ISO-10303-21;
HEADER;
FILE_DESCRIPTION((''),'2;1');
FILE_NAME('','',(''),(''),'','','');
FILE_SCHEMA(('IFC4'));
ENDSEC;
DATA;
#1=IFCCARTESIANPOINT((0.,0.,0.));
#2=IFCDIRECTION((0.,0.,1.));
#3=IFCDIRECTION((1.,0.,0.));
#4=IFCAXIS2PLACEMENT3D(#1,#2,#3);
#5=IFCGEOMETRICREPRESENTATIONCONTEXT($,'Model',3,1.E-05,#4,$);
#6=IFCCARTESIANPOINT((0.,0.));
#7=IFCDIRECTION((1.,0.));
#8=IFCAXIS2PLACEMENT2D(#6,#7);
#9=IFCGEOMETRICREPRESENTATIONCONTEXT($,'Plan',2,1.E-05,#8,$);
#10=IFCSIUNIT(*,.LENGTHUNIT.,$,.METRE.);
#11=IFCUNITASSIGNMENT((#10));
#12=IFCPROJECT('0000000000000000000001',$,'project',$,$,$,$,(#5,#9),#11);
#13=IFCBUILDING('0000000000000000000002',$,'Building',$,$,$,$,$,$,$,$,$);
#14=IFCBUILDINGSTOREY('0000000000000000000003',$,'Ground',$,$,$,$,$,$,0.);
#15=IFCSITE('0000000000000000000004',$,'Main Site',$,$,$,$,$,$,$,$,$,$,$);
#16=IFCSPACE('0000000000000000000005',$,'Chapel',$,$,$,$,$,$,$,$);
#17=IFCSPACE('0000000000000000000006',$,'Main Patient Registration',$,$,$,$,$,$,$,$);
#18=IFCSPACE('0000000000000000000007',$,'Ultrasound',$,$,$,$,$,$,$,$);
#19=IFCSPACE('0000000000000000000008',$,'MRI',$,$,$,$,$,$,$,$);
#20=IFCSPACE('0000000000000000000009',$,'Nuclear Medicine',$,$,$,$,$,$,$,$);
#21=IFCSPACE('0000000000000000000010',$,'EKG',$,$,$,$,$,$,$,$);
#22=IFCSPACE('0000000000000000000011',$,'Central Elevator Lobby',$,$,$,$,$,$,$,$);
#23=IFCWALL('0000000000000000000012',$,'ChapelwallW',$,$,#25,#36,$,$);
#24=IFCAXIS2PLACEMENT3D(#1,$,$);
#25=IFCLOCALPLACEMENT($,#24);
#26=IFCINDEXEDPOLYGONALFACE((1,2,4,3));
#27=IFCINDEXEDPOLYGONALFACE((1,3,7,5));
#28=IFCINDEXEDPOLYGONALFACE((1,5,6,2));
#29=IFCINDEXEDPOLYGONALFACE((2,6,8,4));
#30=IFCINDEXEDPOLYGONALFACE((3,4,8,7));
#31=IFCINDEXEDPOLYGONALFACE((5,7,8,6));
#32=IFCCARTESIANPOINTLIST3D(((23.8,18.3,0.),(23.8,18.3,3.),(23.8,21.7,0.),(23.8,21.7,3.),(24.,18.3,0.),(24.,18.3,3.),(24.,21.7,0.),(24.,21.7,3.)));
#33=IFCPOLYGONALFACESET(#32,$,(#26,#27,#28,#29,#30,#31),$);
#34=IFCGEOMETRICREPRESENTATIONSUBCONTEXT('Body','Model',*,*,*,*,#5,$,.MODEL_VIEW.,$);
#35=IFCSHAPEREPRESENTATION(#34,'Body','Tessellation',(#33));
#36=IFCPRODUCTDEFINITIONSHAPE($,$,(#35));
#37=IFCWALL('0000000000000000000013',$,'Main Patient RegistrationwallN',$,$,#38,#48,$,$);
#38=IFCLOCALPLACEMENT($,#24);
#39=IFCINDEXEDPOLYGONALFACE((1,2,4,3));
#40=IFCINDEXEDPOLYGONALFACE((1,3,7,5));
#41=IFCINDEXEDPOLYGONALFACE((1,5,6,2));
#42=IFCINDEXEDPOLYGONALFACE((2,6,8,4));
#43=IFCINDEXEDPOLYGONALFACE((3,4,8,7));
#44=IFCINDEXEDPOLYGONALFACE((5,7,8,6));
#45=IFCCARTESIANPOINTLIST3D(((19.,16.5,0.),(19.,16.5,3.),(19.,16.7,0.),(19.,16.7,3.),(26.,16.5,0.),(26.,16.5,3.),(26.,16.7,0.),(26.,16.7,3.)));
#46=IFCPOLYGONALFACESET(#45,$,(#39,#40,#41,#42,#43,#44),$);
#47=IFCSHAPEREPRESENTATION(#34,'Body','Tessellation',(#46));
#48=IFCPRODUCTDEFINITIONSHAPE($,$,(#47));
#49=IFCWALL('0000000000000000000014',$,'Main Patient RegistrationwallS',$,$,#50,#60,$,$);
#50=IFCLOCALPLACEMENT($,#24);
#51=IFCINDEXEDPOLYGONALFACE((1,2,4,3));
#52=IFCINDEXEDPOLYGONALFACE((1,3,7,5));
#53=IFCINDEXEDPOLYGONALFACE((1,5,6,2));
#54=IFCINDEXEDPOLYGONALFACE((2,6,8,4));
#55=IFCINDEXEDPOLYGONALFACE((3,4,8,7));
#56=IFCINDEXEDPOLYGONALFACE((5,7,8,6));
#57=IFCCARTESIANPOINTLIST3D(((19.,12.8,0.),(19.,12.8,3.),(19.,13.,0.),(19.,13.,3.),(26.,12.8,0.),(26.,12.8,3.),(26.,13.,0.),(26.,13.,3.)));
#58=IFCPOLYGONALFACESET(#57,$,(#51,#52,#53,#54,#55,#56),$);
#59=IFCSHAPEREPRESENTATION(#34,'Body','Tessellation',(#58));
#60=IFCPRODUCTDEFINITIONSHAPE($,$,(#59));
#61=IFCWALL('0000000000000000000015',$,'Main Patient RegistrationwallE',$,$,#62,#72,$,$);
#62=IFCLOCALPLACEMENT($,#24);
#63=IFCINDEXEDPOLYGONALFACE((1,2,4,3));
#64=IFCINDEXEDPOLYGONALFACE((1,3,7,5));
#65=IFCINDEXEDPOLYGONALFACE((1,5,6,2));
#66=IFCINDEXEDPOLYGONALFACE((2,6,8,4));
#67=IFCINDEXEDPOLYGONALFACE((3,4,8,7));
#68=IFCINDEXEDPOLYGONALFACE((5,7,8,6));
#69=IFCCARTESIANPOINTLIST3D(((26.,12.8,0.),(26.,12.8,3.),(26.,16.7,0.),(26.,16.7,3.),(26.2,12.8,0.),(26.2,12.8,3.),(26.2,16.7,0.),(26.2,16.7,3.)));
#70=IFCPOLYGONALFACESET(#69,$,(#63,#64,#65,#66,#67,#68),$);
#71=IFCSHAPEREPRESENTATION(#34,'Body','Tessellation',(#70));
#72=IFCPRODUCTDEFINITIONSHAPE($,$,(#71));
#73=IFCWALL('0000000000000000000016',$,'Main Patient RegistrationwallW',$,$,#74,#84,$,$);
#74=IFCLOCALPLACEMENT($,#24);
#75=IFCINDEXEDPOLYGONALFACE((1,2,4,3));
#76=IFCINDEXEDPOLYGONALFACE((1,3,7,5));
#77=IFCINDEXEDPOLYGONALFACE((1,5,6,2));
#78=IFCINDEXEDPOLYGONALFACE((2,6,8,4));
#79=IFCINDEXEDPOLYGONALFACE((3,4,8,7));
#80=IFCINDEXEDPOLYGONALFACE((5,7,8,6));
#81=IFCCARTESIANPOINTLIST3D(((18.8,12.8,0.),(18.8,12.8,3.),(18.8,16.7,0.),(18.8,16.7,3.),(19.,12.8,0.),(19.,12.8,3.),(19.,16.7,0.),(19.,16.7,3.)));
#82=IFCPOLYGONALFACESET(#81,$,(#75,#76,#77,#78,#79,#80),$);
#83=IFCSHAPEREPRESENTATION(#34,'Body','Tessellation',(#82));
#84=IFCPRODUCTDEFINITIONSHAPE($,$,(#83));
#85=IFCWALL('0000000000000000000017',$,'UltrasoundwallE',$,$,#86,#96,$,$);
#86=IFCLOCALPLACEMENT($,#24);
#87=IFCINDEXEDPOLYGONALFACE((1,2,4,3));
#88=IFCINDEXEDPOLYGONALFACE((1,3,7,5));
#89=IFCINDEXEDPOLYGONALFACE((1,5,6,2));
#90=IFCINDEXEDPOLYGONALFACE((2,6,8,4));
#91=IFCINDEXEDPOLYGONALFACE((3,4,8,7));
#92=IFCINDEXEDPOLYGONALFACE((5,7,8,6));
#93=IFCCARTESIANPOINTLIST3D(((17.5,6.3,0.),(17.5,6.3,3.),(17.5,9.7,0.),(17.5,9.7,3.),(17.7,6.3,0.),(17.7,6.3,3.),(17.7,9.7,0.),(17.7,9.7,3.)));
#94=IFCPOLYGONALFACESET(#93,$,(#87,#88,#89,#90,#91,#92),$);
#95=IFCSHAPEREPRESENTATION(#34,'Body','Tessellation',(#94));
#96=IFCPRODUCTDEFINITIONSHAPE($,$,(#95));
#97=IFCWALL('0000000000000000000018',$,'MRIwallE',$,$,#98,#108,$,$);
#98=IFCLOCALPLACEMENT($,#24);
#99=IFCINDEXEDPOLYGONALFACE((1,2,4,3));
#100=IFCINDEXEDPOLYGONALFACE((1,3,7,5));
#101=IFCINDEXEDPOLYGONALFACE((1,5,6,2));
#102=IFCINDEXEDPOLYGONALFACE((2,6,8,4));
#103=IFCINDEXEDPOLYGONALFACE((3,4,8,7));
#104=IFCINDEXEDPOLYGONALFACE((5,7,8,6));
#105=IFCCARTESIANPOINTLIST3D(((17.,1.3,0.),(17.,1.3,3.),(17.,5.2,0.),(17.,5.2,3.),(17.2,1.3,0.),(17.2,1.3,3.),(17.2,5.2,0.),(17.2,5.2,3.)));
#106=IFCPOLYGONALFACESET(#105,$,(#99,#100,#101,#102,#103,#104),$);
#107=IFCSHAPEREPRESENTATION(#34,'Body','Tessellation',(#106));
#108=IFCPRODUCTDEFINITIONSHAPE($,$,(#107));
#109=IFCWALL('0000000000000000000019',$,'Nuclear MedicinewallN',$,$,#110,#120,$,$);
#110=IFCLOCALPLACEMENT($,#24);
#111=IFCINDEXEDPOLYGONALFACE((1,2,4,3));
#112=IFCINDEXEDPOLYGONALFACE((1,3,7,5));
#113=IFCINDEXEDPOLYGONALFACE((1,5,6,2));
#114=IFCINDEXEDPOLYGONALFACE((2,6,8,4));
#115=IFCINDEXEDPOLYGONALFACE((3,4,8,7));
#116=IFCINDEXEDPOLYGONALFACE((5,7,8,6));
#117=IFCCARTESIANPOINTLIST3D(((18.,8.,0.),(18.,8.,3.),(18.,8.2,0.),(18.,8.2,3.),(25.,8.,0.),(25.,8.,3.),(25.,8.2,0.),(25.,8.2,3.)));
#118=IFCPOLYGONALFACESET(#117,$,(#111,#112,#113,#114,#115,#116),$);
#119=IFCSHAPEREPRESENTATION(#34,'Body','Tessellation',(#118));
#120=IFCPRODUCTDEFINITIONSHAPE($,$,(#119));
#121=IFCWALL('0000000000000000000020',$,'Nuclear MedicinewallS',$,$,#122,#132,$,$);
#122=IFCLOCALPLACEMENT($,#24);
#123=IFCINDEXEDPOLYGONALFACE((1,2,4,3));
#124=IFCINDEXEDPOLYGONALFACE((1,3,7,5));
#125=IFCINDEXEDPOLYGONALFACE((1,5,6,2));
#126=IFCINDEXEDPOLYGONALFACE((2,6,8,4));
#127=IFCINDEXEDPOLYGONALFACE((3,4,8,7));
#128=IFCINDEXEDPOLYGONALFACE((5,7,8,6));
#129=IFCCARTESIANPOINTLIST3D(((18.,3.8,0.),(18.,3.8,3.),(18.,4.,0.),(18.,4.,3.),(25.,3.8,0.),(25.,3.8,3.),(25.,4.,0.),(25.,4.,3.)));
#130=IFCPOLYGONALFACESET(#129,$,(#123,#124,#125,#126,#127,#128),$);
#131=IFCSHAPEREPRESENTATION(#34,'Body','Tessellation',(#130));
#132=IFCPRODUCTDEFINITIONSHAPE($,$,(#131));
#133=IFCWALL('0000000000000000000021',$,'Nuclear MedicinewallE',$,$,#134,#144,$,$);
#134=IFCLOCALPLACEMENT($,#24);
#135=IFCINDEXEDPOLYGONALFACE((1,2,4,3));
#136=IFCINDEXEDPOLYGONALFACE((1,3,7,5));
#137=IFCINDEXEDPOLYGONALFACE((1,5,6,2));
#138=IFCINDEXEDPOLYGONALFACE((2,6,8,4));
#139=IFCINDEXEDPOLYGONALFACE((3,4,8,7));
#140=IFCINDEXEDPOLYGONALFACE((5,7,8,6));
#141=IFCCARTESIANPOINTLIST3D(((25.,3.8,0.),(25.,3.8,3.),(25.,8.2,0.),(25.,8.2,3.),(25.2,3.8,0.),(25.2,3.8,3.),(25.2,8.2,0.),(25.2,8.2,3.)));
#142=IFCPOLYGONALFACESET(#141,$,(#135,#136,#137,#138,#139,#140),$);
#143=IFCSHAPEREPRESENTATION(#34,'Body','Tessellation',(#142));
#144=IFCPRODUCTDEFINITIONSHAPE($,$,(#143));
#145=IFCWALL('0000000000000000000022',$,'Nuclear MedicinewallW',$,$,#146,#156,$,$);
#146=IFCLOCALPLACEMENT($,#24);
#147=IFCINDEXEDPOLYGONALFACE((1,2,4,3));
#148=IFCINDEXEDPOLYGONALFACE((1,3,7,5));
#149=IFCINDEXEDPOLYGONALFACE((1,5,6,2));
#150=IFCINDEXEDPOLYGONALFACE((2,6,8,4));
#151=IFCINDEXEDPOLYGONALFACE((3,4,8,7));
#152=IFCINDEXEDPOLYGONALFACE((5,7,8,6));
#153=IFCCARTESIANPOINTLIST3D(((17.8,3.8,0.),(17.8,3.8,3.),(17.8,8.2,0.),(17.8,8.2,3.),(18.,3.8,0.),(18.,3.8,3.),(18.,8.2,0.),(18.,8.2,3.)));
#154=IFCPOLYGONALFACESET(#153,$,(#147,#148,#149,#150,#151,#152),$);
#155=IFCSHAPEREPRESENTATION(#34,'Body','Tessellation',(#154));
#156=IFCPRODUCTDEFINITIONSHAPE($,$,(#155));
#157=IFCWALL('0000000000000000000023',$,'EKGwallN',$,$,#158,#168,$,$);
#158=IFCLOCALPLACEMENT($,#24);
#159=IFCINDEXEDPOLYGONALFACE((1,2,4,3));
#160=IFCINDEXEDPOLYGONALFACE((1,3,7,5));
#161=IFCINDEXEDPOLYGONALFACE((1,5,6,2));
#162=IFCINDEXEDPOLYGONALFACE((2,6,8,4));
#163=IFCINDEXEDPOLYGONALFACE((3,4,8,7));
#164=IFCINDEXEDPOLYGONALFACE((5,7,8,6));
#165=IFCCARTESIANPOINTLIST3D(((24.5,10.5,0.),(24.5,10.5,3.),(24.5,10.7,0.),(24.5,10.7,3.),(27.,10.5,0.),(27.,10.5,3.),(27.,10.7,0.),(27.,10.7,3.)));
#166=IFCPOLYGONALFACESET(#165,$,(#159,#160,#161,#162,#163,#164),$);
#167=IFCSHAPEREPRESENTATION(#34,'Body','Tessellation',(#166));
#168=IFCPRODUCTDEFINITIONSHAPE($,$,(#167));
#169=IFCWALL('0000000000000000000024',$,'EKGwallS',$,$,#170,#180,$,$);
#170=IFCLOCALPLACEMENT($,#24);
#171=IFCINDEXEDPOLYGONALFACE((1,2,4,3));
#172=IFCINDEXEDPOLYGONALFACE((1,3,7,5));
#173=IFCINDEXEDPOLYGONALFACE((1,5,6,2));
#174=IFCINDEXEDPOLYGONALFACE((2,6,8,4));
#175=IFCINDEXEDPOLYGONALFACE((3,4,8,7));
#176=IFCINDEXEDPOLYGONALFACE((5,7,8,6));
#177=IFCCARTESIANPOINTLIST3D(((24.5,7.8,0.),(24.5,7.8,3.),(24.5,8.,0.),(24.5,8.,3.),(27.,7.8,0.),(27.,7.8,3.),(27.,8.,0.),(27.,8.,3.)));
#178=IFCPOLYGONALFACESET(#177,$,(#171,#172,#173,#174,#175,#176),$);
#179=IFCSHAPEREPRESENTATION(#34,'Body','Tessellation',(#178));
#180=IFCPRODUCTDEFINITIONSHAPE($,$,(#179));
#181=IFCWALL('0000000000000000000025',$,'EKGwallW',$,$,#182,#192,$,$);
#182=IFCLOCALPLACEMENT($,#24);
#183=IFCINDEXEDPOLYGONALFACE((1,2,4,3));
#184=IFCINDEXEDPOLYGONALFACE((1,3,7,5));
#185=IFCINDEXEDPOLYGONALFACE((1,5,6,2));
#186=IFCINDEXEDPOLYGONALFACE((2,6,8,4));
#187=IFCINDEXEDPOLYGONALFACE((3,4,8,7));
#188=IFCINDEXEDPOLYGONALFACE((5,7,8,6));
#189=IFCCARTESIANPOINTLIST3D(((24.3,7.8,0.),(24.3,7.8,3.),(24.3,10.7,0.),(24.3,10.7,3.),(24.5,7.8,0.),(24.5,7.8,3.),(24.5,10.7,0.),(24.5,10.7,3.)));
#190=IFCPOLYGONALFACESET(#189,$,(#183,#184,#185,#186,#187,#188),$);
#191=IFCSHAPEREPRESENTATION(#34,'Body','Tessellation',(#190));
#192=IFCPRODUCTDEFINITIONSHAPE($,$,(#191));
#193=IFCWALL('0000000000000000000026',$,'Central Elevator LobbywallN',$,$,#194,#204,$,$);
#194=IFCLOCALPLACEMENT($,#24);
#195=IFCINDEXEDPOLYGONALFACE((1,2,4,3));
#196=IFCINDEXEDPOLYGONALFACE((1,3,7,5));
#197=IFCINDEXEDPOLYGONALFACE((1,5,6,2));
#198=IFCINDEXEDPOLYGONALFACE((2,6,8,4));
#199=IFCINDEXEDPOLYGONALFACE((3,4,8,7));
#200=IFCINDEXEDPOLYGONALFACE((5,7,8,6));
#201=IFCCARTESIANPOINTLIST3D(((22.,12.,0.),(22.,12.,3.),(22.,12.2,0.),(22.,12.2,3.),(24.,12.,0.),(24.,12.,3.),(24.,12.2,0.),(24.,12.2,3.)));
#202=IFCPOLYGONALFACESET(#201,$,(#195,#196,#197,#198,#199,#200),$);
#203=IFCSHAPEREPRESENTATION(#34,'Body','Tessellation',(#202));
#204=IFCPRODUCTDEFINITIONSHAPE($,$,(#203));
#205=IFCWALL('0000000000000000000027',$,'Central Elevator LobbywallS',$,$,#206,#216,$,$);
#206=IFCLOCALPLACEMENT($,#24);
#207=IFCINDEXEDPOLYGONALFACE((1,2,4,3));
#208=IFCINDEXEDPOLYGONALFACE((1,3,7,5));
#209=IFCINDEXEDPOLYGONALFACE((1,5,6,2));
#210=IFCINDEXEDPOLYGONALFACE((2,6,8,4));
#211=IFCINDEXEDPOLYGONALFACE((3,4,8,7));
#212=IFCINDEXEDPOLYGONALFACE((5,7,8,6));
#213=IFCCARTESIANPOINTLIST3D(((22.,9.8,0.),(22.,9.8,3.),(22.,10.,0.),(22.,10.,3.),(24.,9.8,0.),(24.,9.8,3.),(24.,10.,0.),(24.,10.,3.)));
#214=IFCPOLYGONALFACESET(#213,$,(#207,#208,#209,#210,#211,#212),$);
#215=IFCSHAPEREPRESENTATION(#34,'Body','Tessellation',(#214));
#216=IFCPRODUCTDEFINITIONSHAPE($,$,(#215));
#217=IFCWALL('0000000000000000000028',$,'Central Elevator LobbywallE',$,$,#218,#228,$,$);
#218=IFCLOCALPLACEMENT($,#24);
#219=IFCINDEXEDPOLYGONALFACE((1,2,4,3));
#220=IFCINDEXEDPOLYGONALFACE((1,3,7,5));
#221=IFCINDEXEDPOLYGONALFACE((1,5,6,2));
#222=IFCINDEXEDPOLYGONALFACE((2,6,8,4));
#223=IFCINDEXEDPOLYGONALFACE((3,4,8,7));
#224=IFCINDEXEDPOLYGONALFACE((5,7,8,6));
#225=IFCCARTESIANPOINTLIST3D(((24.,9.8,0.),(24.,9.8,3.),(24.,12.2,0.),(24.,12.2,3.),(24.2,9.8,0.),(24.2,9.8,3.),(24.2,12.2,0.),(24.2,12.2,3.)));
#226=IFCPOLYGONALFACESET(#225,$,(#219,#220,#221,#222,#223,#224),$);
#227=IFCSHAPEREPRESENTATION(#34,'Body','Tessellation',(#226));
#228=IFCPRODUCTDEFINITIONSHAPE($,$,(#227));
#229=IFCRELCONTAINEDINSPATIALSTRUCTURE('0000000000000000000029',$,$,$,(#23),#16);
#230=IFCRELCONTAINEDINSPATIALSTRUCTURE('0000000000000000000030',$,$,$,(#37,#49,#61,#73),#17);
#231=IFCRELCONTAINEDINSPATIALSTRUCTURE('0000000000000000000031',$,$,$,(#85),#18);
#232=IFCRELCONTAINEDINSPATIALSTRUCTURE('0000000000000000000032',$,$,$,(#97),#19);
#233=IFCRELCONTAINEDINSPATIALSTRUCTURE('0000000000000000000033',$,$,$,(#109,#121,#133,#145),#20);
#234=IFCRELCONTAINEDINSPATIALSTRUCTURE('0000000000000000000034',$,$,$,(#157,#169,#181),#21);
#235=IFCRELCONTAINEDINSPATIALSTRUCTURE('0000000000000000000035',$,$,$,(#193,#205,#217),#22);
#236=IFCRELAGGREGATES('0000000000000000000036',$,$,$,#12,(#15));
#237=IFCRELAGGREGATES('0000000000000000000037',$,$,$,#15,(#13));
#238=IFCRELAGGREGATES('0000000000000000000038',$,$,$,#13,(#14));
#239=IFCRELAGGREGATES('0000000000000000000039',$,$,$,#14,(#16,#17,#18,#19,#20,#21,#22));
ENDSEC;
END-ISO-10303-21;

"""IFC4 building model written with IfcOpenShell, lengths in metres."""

from ifc_helpers import new_model, si_unit, frame, origin_with_axes, origin_2d_with_axis, place, context, subcontext, project, spatial, indexed_curve, outline, extrude, element, save


model = new_model("IFC4")

# Units and contexts
model_context = context("Model", 3, precision=1e-05, world=origin_with_axes())
plan_context = context("Plan", 2, precision=1e-05, world=origin_2d_with_axis())
body_context = subcontext(model_context, "Body", "Model", "MODEL_VIEW")
ifc_project = project(units=[si_unit("LENGTHUNIT", "METRE")], contexts=[model_context, plan_context])

# Site, building, storey
site = spatial("IfcSite", under=ifc_project, Name="Main Site")
building = spatial("IfcBuilding", under=site, Name="Building")
storey = spatial("IfcBuildingStorey", under=building, Name="Ground", Elevation=0.0)

# Shared definitions
space_1 = spatial("IfcSpace", under=storey, Name="Chapel")

# Shared definitions
space_2 = spatial("IfcSpace", under=storey, Name="Main Patient Registration")

# Shared definitions
space_3 = spatial("IfcSpace", under=storey, Name="Ultrasound")

# Shared definitions
space_4 = spatial("IfcSpace", under=storey, Name="MRI")

# Shared definitions
space_5 = spatial("IfcSpace", under=storey, Name="Nuclear Medicine")

# Shared definitions
space_6 = spatial("IfcSpace", under=storey, Name="EKG")

# Shared definitions
space_7 = spatial("IfcSpace", under=storey, Name="Central Elevator Lobby")

# Walls
wall_1_placement = place(None, frame((24.0, 18.3, 0.0), z_axis=(0.0, 0.0, 1.0), x_axis=(0.0, 1.0, 0.0)))
element("IfcWall", 1, at=wall_1_placement, inside=space_1, Name="ChapelwallW", context=body_context, shape_type="SweptSolid", body=[
    extrude(outline(indexed_curve([(0.0, 0.0), (0.0, 0.2), (3.4, 0.2), (3.4, 0.0), (0.0, 0.0)], self_intersect=False)), origin_with_axes(), (0.0, 0.0, 1.0), 3.0),
])
for number, where, z_axis, x_axis, name in (
    (2, (19.0, 16.5, 0.0), (0.0, 0.0, 1.0), (1.0, 0.0, 0.0), "Main Patient RegistrationwallN"),
    (3, (19.0, 12.8, 0.0), (0.0, 0.0, 1.0), (1.0, 0.0, 0.0), "Main Patient RegistrationwallS"),
):
    element("IfcWall", number, at=place(None, frame(where, z_axis=z_axis, x_axis=x_axis)), inside=space_2, Name=name, context=body_context, shape_type="SweptSolid", body=[
        extrude(outline(indexed_curve([(0.0, 0.0), (0.0, 0.2), (7.0, 0.2), (7.0, 0.0), (0.0, 0.0)], self_intersect=False)), origin_with_axes(), (0.0, 0.0, 1.0), 3.0),
    ])
for number, where, z_axis, x_axis, name in (
    (4, (26.2, 12.8, 0.0), (0.0, 0.0, 1.0), (0.0, 1.0, 0.0), "Main Patient RegistrationwallE"),
    (5, (19.0, 12.8, 0.0), (0.0, 0.0, 1.0), (0.0, 1.0, 0.0), "Main Patient RegistrationwallW"),
):
    element("IfcWall", number, at=place(None, frame(where, z_axis=z_axis, x_axis=x_axis)), inside=space_2, Name=name, context=body_context, shape_type="SweptSolid", body=[
        extrude(outline(indexed_curve([(0.0, 0.0), (0.0, 0.2), (3.9, 0.2), (3.9, 0.0), (0.0, 0.0)], self_intersect=False)), origin_with_axes(), (0.0, 0.0, 1.0), 3.0),
    ])
wall_2_placement = place(None, frame((17.7, 6.3, 0.0), z_axis=(0.0, 0.0, 1.0), x_axis=(0.0, 1.0, 0.0)))
element("IfcWall", 6, at=wall_2_placement, inside=space_3, Name="UltrasoundwallE", context=body_context, shape_type="SweptSolid", body=[
    extrude(outline(indexed_curve([(0.0, 0.0), (0.0, 0.2), (3.4, 0.2), (3.4, 0.0), (0.0, 0.0)], self_intersect=False)), origin_with_axes(), (0.0, 0.0, 1.0), 3.0),
])
wall_3_placement = place(None, frame((17.2, 1.3, 0.0), z_axis=(0.0, 0.0, 1.0), x_axis=(0.0, 1.0, 0.0)))
element("IfcWall", 7, at=wall_3_placement, inside=space_4, Name="MRIwallE", context=body_context, shape_type="SweptSolid", body=[
    extrude(outline(indexed_curve([(0.0, 0.0), (0.0, 0.2), (3.9, 0.2), (3.9, 0.0), (0.0, 0.0)], self_intersect=False)), origin_with_axes(), (0.0, 0.0, 1.0), 3.0),
])
for number, where, z_axis, x_axis, name in (
    (8, (18.0, 8.0, 0.0), (0.0, 0.0, 1.0), (1.0, 0.0, 0.0), "Nuclear MedicinewallN"),
    (9, (18.0, 3.8, 0.0), (0.0, 0.0, 1.0), (1.0, 0.0, 0.0), "Nuclear MedicinewallS"),
):
    element("IfcWall", number, at=place(None, frame(where, z_axis=z_axis, x_axis=x_axis)), inside=space_5, Name=name, context=body_context, shape_type="SweptSolid", body=[
        extrude(outline(indexed_curve([(0.0, 0.0), (0.0, 0.2), (7.0, 0.2), (7.0, 0.0), (0.0, 0.0)], self_intersect=False)), origin_with_axes(), (0.0, 0.0, 1.0), 3.0),
    ])
for number, where, z_axis, x_axis, name in (
    (10, (25.2, 3.8, 0.0), (0.0, 0.0, 1.0), (0.0, 1.0, 0.0), "Nuclear MedicinewallE"),
    (11, (18.0, 3.8, 0.0), (0.0, 0.0, 1.0), (0.0, 1.0, 0.0), "Nuclear MedicinewallW"),
):
    element("IfcWall", number, at=place(None, frame(where, z_axis=z_axis, x_axis=x_axis)), inside=space_5, Name=name, context=body_context, shape_type="SweptSolid", body=[
        extrude(outline(indexed_curve([(0.0, 0.0), (0.0, 0.2), (4.4, 0.2), (4.4, 0.0), (0.0, 0.0)], self_intersect=False)), origin_with_axes(), (0.0, 0.0, 1.0), 3.0),
    ])
for number, where, z_axis, x_axis, name in (
    (12, (24.5, 10.5, 0.0), (0.0, 0.0, 1.0), (1.0, 0.0, 0.0), "EKGwallN"),
    (13, (24.5, 7.8, 0.0), (0.0, 0.0, 1.0), (1.0, 0.0, 0.0), "EKGwallS"),
):
    element("IfcWall", number, at=place(None, frame(where, z_axis=z_axis, x_axis=x_axis)), inside=space_6, Name=name, context=body_context, shape_type="SweptSolid", body=[
        extrude(outline(indexed_curve([(0.0, 0.0), (0.0, 0.2), (2.5, 0.2), (2.5, 0.0), (0.0, 0.0)], self_intersect=False)), origin_with_axes(), (0.0, 0.0, 1.0), 3.0),
    ])
wall_4_placement = place(None, frame((24.5, 7.8, 0.0), z_axis=(0.0, 0.0, 1.0), x_axis=(0.0, 1.0, 0.0)))
element("IfcWall", 14, at=wall_4_placement, inside=space_6, Name="EKGwallW", context=body_context, shape_type="SweptSolid", body=[
    extrude(outline(indexed_curve([(0.0, 0.0), (0.0, 0.2), (2.9, 0.2), (2.9, 0.0), (0.0, 0.0)], self_intersect=False)), origin_with_axes(), (0.0, 0.0, 1.0), 3.0),
])
for number, where, z_axis, x_axis, name in (
    (15, (22.0, 12.0, 0.0), (0.0, 0.0, 1.0), (1.0, 0.0, 0.0), "Central Elevator LobbywallN"),
    (16, (22.0, 9.8, 0.0), (0.0, 0.0, 1.0), (1.0, 0.0, 0.0), "Central Elevator LobbywallS"),
):
    element("IfcWall", number, at=place(None, frame(where, z_axis=z_axis, x_axis=x_axis)), inside=space_7, Name=name, context=body_context, shape_type="SweptSolid", body=[
        extrude(outline(indexed_curve([(0.0, 0.0), (0.0, 0.2), (2.0, 0.2), (2.0, 0.0), (0.0, 0.0)], self_intersect=False)), origin_with_axes(), (0.0, 0.0, 1.0), 3.0),
    ])
for number, where, z_axis, x_axis, name in (
    (17, (24.2, 9.8, 0.0), (0.0, 0.0, 1.0), (0.0, 1.0, 0.0), "Central Elevator LobbywallE"),
):
    element("IfcWall", number, at=place(None, frame(where, z_axis=z_axis, x_axis=x_axis)), inside=space_7, Name=name, context=body_context, shape_type="SweptSolid", body=[
        extrude(outline(indexed_curve([(0.0, 0.0), (0.0, 0.2), (2.4, 0.2), (2.4, 0.0), (0.0, 0.0)], self_intersect=False)), origin_with_axes(), (0.0, 0.0, 1.0), 3.0),
    ])

save(model, "model.ifc")
